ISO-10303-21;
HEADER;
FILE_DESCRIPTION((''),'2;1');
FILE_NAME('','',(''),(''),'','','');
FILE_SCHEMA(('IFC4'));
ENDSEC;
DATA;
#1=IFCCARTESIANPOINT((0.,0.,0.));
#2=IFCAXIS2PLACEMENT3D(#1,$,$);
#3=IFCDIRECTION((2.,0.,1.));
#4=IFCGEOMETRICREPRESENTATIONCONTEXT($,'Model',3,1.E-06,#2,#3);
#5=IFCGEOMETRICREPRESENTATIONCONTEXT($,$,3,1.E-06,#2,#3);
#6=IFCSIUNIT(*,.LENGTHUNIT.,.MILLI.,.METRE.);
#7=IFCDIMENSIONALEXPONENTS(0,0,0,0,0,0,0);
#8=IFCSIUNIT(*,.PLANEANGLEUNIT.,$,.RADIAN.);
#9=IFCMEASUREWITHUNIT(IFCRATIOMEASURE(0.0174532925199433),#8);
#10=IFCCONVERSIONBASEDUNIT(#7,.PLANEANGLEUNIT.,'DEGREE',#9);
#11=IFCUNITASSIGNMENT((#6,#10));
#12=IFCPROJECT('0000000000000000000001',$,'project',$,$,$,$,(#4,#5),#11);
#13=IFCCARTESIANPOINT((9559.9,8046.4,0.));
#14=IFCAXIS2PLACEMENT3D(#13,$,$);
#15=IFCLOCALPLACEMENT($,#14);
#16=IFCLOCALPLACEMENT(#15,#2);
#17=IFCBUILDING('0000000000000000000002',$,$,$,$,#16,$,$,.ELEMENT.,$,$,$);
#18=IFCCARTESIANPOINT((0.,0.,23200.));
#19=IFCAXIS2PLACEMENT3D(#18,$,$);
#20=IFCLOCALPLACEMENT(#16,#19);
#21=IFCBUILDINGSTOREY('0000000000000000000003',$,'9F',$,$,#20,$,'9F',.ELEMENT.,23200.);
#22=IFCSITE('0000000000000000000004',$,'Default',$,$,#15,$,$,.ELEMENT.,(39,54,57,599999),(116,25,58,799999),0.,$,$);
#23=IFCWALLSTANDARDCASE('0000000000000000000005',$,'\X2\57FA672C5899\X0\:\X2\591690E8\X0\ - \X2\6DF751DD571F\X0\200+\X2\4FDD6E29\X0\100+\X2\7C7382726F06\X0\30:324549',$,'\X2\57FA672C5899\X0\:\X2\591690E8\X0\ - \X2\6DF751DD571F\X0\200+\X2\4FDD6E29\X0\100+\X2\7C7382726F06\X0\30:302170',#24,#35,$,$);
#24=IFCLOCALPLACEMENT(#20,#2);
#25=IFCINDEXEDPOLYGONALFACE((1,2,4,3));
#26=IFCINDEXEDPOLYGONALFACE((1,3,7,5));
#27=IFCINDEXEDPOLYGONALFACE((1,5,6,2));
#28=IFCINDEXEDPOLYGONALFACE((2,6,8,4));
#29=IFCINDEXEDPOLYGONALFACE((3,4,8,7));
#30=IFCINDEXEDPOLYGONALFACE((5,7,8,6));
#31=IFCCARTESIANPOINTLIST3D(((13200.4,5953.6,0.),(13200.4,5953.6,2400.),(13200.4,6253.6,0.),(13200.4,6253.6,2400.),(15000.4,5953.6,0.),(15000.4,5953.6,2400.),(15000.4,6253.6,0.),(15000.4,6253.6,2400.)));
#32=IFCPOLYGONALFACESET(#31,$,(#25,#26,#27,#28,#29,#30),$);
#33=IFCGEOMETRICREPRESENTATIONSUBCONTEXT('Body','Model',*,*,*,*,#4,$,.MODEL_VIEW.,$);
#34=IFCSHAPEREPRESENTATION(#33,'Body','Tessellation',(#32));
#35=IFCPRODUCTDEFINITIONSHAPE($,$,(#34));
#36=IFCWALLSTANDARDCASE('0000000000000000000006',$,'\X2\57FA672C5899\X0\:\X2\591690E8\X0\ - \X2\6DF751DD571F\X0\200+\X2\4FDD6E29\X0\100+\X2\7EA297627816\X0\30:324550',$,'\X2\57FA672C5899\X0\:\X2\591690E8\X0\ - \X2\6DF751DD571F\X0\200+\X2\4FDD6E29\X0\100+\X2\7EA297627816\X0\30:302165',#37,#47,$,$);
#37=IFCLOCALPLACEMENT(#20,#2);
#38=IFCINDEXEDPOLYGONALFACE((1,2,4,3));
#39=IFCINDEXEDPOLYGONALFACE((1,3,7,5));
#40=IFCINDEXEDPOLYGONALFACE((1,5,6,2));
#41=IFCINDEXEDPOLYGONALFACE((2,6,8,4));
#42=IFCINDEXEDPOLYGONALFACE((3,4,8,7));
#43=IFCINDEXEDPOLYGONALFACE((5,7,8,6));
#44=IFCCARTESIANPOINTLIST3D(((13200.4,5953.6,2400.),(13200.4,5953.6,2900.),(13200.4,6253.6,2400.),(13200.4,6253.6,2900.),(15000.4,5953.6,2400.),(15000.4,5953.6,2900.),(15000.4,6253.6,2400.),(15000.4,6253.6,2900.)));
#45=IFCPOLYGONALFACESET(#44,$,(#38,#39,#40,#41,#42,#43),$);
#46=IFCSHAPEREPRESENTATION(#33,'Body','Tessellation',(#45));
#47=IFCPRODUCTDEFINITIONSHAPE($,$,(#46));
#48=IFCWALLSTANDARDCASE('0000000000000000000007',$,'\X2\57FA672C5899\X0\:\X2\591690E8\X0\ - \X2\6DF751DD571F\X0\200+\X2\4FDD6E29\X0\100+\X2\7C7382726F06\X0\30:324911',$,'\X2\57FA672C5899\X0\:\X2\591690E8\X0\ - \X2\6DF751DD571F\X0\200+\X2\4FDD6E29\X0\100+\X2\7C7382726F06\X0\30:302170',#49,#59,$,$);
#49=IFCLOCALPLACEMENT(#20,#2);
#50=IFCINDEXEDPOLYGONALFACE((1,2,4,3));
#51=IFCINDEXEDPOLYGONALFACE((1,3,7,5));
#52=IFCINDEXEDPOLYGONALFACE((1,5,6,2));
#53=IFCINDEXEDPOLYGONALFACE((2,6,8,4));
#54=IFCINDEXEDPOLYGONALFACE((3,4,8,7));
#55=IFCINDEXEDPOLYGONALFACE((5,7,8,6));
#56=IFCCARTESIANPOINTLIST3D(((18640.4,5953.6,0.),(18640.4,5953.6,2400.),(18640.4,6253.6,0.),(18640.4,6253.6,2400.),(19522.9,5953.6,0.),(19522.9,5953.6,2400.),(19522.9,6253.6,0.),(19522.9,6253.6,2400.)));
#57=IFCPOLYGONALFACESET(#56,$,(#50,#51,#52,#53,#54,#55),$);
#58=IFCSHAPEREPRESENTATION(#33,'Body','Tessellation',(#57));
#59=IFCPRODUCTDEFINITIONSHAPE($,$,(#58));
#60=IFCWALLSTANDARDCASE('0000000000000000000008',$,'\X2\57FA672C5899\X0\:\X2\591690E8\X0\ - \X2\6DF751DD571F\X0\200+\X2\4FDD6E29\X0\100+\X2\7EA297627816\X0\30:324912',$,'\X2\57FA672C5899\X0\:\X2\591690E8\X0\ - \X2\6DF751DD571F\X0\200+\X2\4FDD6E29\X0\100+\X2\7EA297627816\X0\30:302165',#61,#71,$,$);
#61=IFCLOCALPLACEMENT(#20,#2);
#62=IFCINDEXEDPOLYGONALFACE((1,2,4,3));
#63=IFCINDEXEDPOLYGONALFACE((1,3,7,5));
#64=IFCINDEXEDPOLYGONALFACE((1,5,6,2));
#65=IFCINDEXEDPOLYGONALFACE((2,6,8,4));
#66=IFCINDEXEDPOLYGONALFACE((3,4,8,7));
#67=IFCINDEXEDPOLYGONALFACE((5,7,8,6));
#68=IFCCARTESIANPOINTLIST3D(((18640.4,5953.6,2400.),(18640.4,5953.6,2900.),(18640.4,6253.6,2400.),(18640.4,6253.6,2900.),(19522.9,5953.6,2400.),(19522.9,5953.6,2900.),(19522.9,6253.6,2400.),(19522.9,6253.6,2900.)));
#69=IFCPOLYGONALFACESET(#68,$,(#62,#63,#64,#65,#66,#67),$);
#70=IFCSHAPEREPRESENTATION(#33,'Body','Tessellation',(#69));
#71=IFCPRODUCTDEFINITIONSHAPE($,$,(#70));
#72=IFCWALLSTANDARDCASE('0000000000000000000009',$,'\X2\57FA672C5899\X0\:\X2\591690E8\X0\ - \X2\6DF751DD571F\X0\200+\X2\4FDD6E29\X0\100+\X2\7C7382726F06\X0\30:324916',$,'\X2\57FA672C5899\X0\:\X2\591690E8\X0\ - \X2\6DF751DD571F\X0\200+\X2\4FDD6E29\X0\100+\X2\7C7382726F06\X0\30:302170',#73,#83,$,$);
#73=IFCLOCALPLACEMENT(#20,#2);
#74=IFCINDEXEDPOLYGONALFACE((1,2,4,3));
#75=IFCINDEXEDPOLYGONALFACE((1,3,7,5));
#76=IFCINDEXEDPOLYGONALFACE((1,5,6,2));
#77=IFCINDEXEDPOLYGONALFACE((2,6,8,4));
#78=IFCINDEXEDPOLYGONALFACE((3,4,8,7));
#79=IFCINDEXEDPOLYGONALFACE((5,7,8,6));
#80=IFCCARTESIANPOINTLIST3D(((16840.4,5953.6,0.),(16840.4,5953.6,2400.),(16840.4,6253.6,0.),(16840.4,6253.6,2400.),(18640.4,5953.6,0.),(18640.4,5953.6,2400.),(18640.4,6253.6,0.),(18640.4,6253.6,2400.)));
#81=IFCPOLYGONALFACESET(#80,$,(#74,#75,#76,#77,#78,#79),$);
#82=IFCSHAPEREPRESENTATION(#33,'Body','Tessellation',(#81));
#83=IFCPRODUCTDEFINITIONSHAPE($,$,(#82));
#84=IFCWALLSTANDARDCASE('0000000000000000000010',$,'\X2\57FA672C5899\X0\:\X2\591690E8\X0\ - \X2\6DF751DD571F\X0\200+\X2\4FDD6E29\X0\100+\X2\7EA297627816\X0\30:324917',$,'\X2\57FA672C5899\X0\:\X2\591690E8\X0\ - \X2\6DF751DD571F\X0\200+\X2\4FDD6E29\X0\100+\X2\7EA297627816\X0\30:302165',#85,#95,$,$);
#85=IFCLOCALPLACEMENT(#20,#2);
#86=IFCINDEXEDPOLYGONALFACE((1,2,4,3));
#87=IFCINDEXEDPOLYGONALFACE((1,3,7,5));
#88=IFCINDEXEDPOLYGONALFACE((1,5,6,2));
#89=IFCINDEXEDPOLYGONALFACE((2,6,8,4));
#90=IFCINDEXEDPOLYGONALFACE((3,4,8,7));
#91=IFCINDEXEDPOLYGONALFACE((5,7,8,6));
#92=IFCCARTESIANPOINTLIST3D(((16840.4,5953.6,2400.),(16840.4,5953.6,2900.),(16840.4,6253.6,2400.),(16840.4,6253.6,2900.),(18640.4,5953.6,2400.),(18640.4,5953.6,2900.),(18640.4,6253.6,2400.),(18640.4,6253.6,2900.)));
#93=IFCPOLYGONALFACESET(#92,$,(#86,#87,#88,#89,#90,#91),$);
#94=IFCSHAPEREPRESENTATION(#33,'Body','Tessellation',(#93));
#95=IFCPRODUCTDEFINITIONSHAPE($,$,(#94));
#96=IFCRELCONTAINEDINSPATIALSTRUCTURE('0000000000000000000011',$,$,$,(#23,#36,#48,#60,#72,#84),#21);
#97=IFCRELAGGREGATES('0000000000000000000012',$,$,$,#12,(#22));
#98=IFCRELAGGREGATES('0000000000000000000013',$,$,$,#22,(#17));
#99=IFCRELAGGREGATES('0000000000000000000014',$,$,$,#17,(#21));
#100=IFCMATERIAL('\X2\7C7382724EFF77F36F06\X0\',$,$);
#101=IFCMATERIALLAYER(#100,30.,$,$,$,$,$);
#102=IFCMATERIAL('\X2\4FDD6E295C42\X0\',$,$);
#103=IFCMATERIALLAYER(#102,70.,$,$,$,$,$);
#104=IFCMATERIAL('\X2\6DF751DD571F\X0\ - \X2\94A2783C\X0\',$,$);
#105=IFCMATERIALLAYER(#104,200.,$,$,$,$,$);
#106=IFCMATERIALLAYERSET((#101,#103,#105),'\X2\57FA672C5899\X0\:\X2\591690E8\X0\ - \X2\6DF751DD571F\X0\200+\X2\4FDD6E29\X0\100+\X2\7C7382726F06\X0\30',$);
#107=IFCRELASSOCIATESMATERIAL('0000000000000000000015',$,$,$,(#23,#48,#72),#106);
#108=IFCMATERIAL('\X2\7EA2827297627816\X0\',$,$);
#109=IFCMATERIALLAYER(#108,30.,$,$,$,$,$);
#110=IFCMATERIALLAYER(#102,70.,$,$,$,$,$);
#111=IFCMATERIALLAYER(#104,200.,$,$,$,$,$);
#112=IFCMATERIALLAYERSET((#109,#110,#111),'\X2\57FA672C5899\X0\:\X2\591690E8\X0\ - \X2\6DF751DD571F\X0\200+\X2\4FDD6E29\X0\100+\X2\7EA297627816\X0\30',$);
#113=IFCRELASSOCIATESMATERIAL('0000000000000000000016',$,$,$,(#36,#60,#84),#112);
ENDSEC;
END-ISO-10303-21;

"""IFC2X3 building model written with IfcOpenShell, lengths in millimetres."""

from ifc_helpers import new_model, entity, si_unit, converted_unit, direction, frame, frame_2d, origin, place, context, subcontext, project, spatial, rectangle, extrude, material, layer, layer_set, layer_usage, element, save


model = new_model("IFC2X3")

# Units and contexts
model_context = context("Model", 3, precision=1e-06, world=origin(), true_north=direction((2.0, 0.0, 1.0)))
context_of_model = context(None, 3, precision=1e-06, world=origin(), true_north=direction((2.0, 0.0, 1.0)))
body_context = subcontext(model_context, "Body", "Model", "MODEL_VIEW")
ifc_project = project(units=[si_unit("LENGTHUNIT", "METRE", prefix="MILLI"), converted_unit("PLANEANGLEUNIT", "DEGREE", entity("IfcRatioMeasure", 0.0174532925199433), si_unit("PLANEANGLEUNIT", "RADIAN"), dimensions=[0, 0, 0, 0, 0, 0, 0])], contexts=[model_context, context_of_model])

# Site, building, storey
site_placement = place(None, frame((9559.9, 8046.4, 0.0)))
site = spatial("IfcSite", under=ifc_project, at=site_placement, Name="Default", CompositionType="ELEMENT", RefLatitude=(39, 54, 57, 599999), RefLongitude=(116, 25, 58, 799999), RefElevation=0.0)
building_placement = place(site_placement, origin())
building = spatial("IfcBuilding", under=site, at=building_placement, CompositionType="ELEMENT")
storey_placement = place(building_placement, frame((0.0, 0.0, 23200.0)))
storey = spatial("IfcBuildingStorey", under=building, at=storey_placement, Name="9F", LongName="9F", CompositionType="ELEMENT", Elevation=23200.0)

# Shared definitions
ifc_material_1 = material(Name="红色面砖")
ifc_layer_1 = layer(ifc_material_1, 30.0)
ifc_material_2 = material(Name="保温层")
ifc_layer_2 = layer(ifc_material_2, 70.0)
ifc_material_3 = material(Name="混凝土 - 钢砼")
ifc_layer_3 = layer(ifc_material_3, 200.0)
ifc_layer_set_1 = layer_set([ifc_layer_1, ifc_layer_2, ifc_layer_3], Name="基本墙:外部 - 混凝土200+保温100+红面砖30")

# Walls
ifc_material_4 = material(Name="米色仿石漆")
ifc_layer_4 = layer(ifc_material_4, 30.0)
ifc_layer_5 = layer(ifc_material_2, 70.0)
ifc_layer_6 = layer(ifc_material_3, 200.0)
ifc_layer_set_2 = layer_set([ifc_layer_4, ifc_layer_5, ifc_layer_6], Name="基本墙:外部 - 混凝土200+保温100+米色漆30")
ifc_layer_usage_1 = layer_usage(ifc_layer_set_2, "AXIS2", "POSITIVE", -150.0)
wall_1_placement = place(storey_placement, frame((15000.4, 6103.6, 0.0), z_axis=(0.0, 0.0, 1.0), x_axis=(-1.0, 0.0, 0.0)))
element("IfcWallStandardCase", 1, at=wall_1_placement, inside=storey, material=ifc_layer_usage_1, Name="基本墙:外部 - 混凝土200+保温100+米色漆30:324549", ObjectType="基本墙:外部 - 混凝土200+保温100+米色漆30:302170", context=body_context, shape_type="SweptSolid", body=[
    extrude(rectangle(XDim=1800.0, YDim=300.0, at=frame_2d((900.0, 0.0), x_axis=(-1.0, 0.0))), origin(), (0.0, 0.0, 1.0), 2400.0),
])
ifc_layer_usage_2 = layer_usage(ifc_layer_set_1, "AXIS2", "POSITIVE", -150.0)
wall_2_placement = place(storey_placement, frame((15000.4, 6103.6, 2400.0), z_axis=(0.0, 0.0, 1.0), x_axis=(-1.0, 0.0, 0.0)))
element("IfcWallStandardCase", 2, at=wall_2_placement, inside=storey, material=ifc_layer_usage_2, Name="基本墙:外部 - 混凝土200+保温100+红面砖30:324550", ObjectType="基本墙:外部 - 混凝土200+保温100+红面砖30:302165", context=body_context, shape_type="SweptSolid", body=[
    extrude(rectangle(XDim=1800.0, YDim=300.0, at=frame_2d((900.0, 0.0), x_axis=(-1.0, 0.0))), origin(), (0.0, 0.0, 1.0), 500.0),
])

# Walls
ifc_layer_usage_3 = layer_usage(ifc_layer_set_2, "AXIS2", "NEGATIVE", 150.0)
wall_3_placement = place(storey_placement, frame((18640.4, 6103.6, 0.0)))
element("IfcWallStandardCase", 3, at=wall_3_placement, inside=storey, material=ifc_layer_usage_3, Name="基本墙:外部 - 混凝土200+保温100+米色漆30:324911", ObjectType="基本墙:外部 - 混凝土200+保温100+米色漆30:302170", context=body_context, shape_type="SweptSolid", body=[
    extrude(rectangle(XDim=882.5, YDim=300.0, at=frame_2d((441.3, 0.0), x_axis=(-1.0, 0.0))), origin(), (0.0, 0.0, 1.0), 2400.0),
])
ifc_layer_usage_4 = layer_usage(ifc_layer_set_1, "AXIS2", "NEGATIVE", 150.0)
wall_4_placement = place(storey_placement, frame((18640.4, 6103.6, 2400.0)))
element("IfcWallStandardCase", 4, at=wall_4_placement, inside=storey, material=ifc_layer_usage_4, Name="基本墙:外部 - 混凝土200+保温100+红面砖30:324912", ObjectType="基本墙:外部 - 混凝土200+保温100+红面砖30:302165", context=body_context, shape_type="SweptSolid", body=[
    extrude(rectangle(XDim=882.5, YDim=300.0, at=frame_2d((441.3, 0.0), x_axis=(-1.0, 0.0))), origin(), (0.0, 0.0, 1.0), 500.0),
])
ifc_layer_usage_5 = layer_usage(ifc_layer_set_2, "AXIS2", "NEGATIVE", 150.0)
wall_5_placement = place(storey_placement, frame((16840.4, 6103.6, 0.0)))
element("IfcWallStandardCase", 5, at=wall_5_placement, inside=storey, material=ifc_layer_usage_5, Name="基本墙:外部 - 混凝土200+保温100+米色漆30:324916", ObjectType="基本墙:外部 - 混凝土200+保温100+米色漆30:302170", context=body_context, shape_type="SweptSolid", body=[
    extrude(rectangle(XDim=1800.0, YDim=300.0, at=frame_2d((900.0, 0.0), x_axis=(-1.0, 0.0))), origin(), (0.0, 0.0, 1.0), 2400.0),
])
ifc_layer_usage_6 = layer_usage(ifc_layer_set_1, "AXIS2", "NEGATIVE", 150.0)
wall_6_placement = place(storey_placement, frame((16840.4, 6103.6, 2400.0)))
element("IfcWallStandardCase", 6, at=wall_6_placement, inside=storey, material=ifc_layer_usage_6, Name="基本墙:外部 - 混凝土200+保温100+红面砖30:324917", ObjectType="基本墙:外部 - 混凝土200+保温100+红面砖30:302165", context=body_context, shape_type="SweptSolid", body=[
    extrude(rectangle(XDim=1800.0, YDim=300.0, at=frame_2d((900.0, 0.0), x_axis=(-1.0, 0.0))), origin(), (0.0, 0.0, 1.0), 500.0),
])

save(model, "model.ifc")
